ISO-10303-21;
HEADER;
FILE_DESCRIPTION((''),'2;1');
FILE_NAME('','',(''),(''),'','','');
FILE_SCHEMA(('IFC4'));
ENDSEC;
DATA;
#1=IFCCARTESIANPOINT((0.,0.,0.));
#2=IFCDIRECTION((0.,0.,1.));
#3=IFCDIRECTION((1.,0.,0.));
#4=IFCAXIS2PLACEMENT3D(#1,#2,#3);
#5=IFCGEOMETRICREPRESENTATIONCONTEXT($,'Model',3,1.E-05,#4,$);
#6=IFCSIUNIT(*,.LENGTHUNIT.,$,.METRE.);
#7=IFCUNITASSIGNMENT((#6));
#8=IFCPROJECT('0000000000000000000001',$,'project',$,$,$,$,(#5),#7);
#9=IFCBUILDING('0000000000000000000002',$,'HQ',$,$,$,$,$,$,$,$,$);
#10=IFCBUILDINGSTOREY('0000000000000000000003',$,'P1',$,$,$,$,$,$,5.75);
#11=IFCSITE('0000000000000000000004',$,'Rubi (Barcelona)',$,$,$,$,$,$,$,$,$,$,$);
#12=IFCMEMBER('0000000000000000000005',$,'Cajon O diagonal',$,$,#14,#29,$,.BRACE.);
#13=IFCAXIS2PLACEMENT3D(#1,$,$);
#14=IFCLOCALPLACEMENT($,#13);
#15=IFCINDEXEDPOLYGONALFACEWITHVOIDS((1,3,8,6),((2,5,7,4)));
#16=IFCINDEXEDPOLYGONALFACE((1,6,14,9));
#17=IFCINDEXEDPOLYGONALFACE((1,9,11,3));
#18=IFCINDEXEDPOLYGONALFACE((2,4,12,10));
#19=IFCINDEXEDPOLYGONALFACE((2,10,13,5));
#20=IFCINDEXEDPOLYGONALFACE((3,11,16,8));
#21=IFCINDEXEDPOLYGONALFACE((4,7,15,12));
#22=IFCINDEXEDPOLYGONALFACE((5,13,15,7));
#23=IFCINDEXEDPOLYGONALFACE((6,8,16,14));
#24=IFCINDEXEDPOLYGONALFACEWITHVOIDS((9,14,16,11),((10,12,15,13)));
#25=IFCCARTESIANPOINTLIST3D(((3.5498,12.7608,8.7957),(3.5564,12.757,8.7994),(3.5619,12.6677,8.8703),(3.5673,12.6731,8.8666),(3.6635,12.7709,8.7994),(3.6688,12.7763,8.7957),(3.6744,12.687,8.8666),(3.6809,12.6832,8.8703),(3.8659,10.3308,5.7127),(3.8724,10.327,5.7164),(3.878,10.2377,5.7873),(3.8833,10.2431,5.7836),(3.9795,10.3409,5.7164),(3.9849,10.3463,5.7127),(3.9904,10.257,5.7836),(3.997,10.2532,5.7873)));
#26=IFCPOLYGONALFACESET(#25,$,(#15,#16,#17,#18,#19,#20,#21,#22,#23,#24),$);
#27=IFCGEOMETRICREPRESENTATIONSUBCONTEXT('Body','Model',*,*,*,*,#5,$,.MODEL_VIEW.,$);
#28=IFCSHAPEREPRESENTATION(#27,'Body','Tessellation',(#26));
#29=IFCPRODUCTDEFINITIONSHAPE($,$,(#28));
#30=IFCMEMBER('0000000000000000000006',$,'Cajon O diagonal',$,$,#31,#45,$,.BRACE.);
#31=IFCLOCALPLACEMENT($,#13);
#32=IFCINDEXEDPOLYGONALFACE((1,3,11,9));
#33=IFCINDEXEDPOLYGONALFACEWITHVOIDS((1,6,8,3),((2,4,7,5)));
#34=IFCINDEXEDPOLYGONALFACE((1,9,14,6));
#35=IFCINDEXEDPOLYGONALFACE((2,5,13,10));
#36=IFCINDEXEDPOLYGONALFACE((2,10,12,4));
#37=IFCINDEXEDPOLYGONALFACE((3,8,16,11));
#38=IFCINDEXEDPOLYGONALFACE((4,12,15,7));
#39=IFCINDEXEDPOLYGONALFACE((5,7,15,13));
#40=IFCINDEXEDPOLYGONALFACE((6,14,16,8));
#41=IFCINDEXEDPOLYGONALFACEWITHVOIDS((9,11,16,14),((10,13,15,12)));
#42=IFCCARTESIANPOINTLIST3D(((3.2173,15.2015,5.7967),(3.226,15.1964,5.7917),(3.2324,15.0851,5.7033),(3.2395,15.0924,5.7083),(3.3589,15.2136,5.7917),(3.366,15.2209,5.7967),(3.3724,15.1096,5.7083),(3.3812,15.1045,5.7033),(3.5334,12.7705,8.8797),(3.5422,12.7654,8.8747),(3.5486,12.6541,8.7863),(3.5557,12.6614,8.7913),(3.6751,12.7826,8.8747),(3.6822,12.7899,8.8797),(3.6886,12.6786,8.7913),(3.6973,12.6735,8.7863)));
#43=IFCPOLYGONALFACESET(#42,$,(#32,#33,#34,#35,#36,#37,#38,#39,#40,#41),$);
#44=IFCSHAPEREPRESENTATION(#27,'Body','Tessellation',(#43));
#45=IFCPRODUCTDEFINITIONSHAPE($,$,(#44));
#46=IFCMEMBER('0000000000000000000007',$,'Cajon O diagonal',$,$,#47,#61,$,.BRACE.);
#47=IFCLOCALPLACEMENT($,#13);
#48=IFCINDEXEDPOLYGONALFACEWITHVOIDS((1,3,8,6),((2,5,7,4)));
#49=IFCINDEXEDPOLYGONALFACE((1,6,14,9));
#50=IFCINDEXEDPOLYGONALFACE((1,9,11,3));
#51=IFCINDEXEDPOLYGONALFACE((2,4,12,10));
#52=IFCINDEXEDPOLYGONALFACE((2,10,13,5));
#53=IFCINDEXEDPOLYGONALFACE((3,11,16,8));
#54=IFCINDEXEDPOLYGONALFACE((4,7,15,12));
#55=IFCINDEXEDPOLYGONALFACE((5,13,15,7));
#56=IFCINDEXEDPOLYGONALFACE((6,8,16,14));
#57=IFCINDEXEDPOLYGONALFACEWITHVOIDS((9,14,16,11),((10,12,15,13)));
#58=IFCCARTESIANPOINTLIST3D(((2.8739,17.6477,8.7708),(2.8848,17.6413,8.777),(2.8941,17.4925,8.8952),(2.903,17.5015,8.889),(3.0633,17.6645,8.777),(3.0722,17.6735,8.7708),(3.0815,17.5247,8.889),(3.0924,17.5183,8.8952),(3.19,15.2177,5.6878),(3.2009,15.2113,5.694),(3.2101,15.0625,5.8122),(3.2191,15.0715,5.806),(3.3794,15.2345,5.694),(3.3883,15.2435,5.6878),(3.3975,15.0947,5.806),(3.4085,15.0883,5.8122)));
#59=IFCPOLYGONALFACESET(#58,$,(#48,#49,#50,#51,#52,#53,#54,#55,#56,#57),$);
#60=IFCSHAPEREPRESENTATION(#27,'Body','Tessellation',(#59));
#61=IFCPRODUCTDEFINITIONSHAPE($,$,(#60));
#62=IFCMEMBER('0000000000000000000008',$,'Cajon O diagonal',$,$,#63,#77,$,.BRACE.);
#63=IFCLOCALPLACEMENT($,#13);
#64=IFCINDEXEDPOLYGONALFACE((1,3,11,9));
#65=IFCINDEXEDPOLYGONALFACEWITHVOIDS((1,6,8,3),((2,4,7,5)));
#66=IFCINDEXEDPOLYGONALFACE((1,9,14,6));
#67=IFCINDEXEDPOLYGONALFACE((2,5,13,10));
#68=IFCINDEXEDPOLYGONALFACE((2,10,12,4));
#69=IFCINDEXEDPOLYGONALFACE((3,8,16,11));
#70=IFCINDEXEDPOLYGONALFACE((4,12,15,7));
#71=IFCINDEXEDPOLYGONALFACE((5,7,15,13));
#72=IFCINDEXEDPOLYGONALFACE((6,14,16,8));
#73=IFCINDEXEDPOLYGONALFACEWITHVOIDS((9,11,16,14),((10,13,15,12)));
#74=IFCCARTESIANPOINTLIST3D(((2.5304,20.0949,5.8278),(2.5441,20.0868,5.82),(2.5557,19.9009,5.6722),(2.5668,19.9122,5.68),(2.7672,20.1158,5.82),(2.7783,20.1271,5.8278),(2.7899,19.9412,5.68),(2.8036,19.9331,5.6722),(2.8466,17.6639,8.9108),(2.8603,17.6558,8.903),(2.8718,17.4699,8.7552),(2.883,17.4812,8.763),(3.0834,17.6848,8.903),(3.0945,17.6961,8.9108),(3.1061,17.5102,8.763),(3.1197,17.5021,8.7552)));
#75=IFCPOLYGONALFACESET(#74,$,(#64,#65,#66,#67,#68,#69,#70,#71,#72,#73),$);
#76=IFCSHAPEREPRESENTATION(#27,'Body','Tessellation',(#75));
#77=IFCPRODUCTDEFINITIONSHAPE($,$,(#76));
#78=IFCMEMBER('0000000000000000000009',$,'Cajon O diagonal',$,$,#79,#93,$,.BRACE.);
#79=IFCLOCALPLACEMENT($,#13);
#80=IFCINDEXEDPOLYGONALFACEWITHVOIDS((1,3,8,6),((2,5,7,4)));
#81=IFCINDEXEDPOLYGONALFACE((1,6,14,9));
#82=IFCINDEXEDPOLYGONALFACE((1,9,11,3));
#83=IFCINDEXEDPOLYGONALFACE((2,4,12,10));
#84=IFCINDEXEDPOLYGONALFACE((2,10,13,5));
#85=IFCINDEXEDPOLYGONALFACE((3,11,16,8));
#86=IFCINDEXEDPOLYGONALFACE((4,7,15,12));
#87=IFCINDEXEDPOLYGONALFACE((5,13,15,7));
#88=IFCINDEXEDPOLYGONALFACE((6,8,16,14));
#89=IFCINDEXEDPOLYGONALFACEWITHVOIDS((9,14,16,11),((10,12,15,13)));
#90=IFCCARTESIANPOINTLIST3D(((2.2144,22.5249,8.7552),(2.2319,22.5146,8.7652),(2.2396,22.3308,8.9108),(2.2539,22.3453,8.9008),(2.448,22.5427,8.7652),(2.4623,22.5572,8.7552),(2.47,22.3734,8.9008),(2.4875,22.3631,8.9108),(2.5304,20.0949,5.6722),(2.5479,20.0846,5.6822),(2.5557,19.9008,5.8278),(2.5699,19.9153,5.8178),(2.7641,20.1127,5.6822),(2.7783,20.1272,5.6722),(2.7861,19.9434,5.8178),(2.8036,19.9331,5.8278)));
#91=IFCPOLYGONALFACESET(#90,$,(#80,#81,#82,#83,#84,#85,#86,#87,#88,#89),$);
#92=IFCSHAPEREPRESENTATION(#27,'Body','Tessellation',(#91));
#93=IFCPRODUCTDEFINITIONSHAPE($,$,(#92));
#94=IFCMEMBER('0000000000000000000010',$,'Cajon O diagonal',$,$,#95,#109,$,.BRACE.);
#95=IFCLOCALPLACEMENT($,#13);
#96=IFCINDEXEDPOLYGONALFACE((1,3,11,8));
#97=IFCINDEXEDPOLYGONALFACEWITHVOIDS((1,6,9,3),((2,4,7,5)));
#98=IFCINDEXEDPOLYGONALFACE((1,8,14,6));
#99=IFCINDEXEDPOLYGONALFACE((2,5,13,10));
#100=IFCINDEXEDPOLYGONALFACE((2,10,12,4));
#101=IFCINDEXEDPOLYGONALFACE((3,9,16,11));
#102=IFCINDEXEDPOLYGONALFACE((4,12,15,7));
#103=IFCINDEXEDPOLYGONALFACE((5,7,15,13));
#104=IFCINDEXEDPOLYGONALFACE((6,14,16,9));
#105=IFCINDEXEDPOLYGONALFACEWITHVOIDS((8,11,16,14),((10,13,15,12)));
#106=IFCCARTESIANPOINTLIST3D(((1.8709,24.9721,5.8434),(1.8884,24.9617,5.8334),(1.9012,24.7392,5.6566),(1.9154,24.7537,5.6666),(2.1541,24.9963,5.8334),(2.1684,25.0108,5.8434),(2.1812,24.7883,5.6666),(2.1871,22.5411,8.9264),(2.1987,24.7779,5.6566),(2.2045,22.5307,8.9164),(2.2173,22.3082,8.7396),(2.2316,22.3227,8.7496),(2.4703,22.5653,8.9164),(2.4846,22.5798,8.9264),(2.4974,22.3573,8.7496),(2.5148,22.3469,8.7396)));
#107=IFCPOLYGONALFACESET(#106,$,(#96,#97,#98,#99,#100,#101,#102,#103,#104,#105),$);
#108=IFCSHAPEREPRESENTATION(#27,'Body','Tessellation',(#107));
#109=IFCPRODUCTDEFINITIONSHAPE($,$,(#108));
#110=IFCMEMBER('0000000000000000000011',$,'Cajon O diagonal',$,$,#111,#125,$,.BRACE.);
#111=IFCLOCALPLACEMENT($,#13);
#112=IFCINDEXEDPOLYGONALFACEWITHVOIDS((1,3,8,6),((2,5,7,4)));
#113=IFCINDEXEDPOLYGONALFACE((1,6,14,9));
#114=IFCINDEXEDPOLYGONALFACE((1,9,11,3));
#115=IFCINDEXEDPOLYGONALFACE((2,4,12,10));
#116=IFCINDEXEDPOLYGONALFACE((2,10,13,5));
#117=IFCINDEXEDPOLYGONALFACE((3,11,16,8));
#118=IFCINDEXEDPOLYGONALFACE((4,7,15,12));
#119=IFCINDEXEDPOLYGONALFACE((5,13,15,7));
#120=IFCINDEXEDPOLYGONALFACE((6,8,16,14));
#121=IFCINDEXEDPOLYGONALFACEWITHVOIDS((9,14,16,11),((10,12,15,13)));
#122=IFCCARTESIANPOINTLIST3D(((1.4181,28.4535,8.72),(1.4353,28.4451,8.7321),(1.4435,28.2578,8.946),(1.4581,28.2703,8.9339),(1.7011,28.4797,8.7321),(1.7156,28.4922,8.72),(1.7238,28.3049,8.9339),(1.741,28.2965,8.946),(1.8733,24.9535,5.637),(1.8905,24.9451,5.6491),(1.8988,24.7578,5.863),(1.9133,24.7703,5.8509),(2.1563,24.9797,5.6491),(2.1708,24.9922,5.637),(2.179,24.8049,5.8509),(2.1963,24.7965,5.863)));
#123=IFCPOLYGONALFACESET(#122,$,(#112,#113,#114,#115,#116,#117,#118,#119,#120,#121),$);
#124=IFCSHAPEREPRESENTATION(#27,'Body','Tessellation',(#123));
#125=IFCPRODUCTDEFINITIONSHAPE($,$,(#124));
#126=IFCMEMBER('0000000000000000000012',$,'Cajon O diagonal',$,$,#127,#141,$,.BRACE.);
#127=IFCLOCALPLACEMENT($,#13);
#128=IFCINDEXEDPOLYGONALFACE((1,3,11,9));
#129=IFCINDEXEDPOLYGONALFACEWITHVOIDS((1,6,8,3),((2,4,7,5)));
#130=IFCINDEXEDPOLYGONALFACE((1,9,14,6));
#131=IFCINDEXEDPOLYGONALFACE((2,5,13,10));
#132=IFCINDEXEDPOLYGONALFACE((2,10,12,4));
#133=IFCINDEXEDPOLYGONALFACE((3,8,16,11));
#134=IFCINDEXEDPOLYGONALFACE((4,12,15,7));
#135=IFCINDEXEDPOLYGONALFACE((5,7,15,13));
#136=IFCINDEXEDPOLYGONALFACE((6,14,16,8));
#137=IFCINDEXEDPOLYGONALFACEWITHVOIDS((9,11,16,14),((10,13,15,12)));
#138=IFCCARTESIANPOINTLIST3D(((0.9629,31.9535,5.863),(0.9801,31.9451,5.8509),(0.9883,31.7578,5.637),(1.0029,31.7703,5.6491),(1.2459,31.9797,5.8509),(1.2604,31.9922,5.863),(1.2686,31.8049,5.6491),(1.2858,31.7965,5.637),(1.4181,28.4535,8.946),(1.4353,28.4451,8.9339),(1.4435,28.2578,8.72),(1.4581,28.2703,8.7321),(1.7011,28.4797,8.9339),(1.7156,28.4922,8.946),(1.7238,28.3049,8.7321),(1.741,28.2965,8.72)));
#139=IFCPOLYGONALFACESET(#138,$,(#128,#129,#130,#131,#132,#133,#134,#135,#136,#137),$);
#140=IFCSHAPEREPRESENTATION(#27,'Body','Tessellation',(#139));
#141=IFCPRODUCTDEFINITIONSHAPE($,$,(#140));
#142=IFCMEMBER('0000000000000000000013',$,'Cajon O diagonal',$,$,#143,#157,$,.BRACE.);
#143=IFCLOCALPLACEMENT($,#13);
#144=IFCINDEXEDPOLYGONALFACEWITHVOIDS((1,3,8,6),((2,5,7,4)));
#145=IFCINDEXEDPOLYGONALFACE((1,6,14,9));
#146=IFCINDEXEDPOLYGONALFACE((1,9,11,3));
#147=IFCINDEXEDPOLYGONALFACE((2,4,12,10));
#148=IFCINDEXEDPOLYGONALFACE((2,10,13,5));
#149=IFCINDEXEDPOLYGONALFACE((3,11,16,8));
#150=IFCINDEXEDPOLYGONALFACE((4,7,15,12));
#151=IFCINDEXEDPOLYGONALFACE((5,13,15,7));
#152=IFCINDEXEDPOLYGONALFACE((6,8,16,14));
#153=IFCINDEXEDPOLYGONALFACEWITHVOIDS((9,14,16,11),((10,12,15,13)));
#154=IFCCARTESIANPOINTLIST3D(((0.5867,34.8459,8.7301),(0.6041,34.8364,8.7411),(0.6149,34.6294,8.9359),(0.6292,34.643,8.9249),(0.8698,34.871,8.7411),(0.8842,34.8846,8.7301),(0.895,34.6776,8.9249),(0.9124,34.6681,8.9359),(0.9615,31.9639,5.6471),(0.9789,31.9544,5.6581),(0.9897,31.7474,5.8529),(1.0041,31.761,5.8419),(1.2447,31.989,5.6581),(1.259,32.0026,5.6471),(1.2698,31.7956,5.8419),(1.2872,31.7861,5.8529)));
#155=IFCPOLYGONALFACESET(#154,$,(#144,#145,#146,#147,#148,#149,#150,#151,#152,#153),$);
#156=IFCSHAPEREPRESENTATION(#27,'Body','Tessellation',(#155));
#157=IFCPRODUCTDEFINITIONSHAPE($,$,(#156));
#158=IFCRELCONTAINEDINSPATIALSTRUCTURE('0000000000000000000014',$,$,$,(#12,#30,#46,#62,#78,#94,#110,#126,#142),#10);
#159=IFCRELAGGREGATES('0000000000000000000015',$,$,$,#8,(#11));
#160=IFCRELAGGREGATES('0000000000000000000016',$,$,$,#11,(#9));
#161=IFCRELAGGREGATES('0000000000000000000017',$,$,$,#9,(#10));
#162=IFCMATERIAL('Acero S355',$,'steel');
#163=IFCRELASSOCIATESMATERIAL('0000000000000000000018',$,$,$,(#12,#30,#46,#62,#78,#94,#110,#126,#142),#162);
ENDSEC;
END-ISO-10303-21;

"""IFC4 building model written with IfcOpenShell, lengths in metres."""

from ifc_helpers import new_model, si_unit, frame, origin_with_axes, place, context, subcontext, project, spatial, hollow_rectangle, extrude, material, element, save


model = new_model("IFC4")

# Units and contexts
model_context = context("Model", 3, precision=1e-05, world=origin_with_axes())
body_context = subcontext(model_context, "Body", "Model", "MODEL_VIEW")
ifc_project = project(units=[si_unit("LENGTHUNIT", "METRE")], contexts=[model_context])

# Site, building, storey
site = spatial("IfcSite", under=ifc_project, Name="Rubi (Barcelona)")
building = spatial("IfcBuilding", under=site, Name="HQ")
storey = spatial("IfcBuildingStorey", under=building, Name="P1", Elevation=5.75)

# Members
ifc_material = material(Name="Acero S355", Category="steel")
member_1_placement = place(None, origin_with_axes())
element("IfcMember", 1, at=member_1_placement, inside=storey, material=ifc_material, Name="Cajon O diagonal", PredefinedType="BRACE", context=body_context, shape_type="SweptSolid", body=[
    extrude(hollow_rectangle(XDim=0.12, YDim=0.12, WallThickness=0.006), frame((3.9314, 10.292, 5.75), z_axis=(-0.08025, 0.617028, 0.782839), x_axis=(-0.991648, -0.128973, 0.0)), (0.0, 0.0, 1.0), 3.9382),
])
member_2_placement = place(None, origin_with_axes())
element("IfcMember", 2, at=member_2_placement, inside=storey, material=ifc_material, Name="Cajon O diagonal", PredefinedType="BRACE", context=body_context, shape_type="SweptSolid", body=[
    extrude(hollow_rectangle(XDim=0.15, YDim=0.15, WallThickness=0.008), frame((3.2992, 15.153, 5.75), z_axis=(0.08027, -0.617184, 0.782714), x_axis=(0.991648, 0.128973, 0.0)), (0.0, 0.0, 1.0), 3.9389),
])
member_3_placement = place(None, origin_with_axes())
element("IfcMember", 3, at=member_3_placement, inside=storey, material=ifc_material, Name="Cajon O diagonal", PredefinedType="BRACE", context=body_context, shape_type="SweptSolid", body=[
    extrude(hollow_rectangle(XDim=0.2, YDim=0.2, WallThickness=0.01), frame((3.2992, 15.153, 5.75), z_axis=(-0.08025, 0.617028, 0.782839), x_axis=(-0.991648, -0.128973, 0.0)), (0.0, 0.0, 1.0), 3.9382),
])
member_4_placement = place(None, origin_with_axes())
element("IfcMember", 4, at=member_4_placement, inside=storey, material=ifc_material, Name="Cajon O diagonal", PredefinedType="BRACE", context=body_context, shape_type="SweptSolid", body=[
    extrude(hollow_rectangle(XDim=0.25, YDim=0.25, WallThickness=0.0125), frame((2.667, 20.014, 5.75), z_axis=(0.08027, -0.617184, 0.782714), x_axis=(0.991648, 0.128973, 0.0)), (0.0, 0.0, 1.0), 3.9389),
])
member_5_placement = place(None, origin_with_axes())
element("IfcMember", 5, at=member_5_placement, inside=storey, material=ifc_material, Name="Cajon O diagonal", PredefinedType="BRACE", context=body_context, shape_type="SweptSolid", body=[
    extrude(hollow_rectangle(XDim=0.25, YDim=0.25, WallThickness=0.016), frame((2.667, 20.014, 5.75), z_axis=(-0.08025, 0.617028, 0.782839), x_axis=(-0.991648, -0.128973, 0.0)), (0.0, 0.0, 1.0), 3.9382),
])
member_6_placement = place(None, origin_with_axes())
element("IfcMember", 6, at=member_6_placement, inside=storey, material=ifc_material, Name="Cajon O diagonal", PredefinedType="BRACE", context=body_context, shape_type="SweptSolid", body=[
    extrude(hollow_rectangle(XDim=0.3, YDim=0.3, WallThickness=0.016), frame((2.0348, 24.875, 5.75), z_axis=(0.08027, -0.617184, 0.782714), x_axis=(0.991648, 0.128973, 0.0)), (0.0, 0.0, 1.0), 3.9389),
])
member_7_placement = place(None, origin_with_axes())
element("IfcMember", 7, at=member_7_placement, inside=storey, material=ifc_material, Name="Cajon O diagonal", PredefinedType="BRACE", context=body_context, shape_type="SweptSolid", body=[
    extrude(hollow_rectangle(XDim=0.3, YDim=0.3, WallThickness=0.016), frame((2.0348, 24.875, 5.75), z_axis=(-0.097134, 0.746846, 0.657865), x_axis=(-0.991648, -0.128973, 0.0)), (0.0, 0.0, 1.0), 4.6864),
])
member_8_placement = place(None, origin_with_axes())
element("IfcMember", 8, at=member_8_placement, inside=storey, material=ifc_material, Name="Cajon O diagonal", PredefinedType="BRACE", context=body_context, shape_type="SweptSolid", body=[
    extrude(hollow_rectangle(XDim=0.3, YDim=0.3, WallThickness=0.016), frame((1.1244, 31.875, 5.75), z_axis=(0.097134, -0.746846, 0.657865), x_axis=(0.991648, 0.128973, 0.0)), (0.0, 0.0, 1.0), 4.6864),
])
member_9_placement = place(None, origin_with_axes())
element("IfcMember", 9, at=member_9_placement, inside=storey, material=ifc_material, Name="Cajon O diagonal", PredefinedType="BRACE", context=body_context, shape_type="SweptSolid", body=[
    extrude(hollow_rectangle(XDim=0.3, YDim=0.3, WallThickness=0.016), frame((1.1244, 31.875, 5.75), z_axis=(-0.088468, 0.680215, 0.727655), x_axis=(-0.991648, -0.128973, 0.0)), (0.0, 0.0, 1.0), 4.2369),
])

save(model, "model.ifc")
